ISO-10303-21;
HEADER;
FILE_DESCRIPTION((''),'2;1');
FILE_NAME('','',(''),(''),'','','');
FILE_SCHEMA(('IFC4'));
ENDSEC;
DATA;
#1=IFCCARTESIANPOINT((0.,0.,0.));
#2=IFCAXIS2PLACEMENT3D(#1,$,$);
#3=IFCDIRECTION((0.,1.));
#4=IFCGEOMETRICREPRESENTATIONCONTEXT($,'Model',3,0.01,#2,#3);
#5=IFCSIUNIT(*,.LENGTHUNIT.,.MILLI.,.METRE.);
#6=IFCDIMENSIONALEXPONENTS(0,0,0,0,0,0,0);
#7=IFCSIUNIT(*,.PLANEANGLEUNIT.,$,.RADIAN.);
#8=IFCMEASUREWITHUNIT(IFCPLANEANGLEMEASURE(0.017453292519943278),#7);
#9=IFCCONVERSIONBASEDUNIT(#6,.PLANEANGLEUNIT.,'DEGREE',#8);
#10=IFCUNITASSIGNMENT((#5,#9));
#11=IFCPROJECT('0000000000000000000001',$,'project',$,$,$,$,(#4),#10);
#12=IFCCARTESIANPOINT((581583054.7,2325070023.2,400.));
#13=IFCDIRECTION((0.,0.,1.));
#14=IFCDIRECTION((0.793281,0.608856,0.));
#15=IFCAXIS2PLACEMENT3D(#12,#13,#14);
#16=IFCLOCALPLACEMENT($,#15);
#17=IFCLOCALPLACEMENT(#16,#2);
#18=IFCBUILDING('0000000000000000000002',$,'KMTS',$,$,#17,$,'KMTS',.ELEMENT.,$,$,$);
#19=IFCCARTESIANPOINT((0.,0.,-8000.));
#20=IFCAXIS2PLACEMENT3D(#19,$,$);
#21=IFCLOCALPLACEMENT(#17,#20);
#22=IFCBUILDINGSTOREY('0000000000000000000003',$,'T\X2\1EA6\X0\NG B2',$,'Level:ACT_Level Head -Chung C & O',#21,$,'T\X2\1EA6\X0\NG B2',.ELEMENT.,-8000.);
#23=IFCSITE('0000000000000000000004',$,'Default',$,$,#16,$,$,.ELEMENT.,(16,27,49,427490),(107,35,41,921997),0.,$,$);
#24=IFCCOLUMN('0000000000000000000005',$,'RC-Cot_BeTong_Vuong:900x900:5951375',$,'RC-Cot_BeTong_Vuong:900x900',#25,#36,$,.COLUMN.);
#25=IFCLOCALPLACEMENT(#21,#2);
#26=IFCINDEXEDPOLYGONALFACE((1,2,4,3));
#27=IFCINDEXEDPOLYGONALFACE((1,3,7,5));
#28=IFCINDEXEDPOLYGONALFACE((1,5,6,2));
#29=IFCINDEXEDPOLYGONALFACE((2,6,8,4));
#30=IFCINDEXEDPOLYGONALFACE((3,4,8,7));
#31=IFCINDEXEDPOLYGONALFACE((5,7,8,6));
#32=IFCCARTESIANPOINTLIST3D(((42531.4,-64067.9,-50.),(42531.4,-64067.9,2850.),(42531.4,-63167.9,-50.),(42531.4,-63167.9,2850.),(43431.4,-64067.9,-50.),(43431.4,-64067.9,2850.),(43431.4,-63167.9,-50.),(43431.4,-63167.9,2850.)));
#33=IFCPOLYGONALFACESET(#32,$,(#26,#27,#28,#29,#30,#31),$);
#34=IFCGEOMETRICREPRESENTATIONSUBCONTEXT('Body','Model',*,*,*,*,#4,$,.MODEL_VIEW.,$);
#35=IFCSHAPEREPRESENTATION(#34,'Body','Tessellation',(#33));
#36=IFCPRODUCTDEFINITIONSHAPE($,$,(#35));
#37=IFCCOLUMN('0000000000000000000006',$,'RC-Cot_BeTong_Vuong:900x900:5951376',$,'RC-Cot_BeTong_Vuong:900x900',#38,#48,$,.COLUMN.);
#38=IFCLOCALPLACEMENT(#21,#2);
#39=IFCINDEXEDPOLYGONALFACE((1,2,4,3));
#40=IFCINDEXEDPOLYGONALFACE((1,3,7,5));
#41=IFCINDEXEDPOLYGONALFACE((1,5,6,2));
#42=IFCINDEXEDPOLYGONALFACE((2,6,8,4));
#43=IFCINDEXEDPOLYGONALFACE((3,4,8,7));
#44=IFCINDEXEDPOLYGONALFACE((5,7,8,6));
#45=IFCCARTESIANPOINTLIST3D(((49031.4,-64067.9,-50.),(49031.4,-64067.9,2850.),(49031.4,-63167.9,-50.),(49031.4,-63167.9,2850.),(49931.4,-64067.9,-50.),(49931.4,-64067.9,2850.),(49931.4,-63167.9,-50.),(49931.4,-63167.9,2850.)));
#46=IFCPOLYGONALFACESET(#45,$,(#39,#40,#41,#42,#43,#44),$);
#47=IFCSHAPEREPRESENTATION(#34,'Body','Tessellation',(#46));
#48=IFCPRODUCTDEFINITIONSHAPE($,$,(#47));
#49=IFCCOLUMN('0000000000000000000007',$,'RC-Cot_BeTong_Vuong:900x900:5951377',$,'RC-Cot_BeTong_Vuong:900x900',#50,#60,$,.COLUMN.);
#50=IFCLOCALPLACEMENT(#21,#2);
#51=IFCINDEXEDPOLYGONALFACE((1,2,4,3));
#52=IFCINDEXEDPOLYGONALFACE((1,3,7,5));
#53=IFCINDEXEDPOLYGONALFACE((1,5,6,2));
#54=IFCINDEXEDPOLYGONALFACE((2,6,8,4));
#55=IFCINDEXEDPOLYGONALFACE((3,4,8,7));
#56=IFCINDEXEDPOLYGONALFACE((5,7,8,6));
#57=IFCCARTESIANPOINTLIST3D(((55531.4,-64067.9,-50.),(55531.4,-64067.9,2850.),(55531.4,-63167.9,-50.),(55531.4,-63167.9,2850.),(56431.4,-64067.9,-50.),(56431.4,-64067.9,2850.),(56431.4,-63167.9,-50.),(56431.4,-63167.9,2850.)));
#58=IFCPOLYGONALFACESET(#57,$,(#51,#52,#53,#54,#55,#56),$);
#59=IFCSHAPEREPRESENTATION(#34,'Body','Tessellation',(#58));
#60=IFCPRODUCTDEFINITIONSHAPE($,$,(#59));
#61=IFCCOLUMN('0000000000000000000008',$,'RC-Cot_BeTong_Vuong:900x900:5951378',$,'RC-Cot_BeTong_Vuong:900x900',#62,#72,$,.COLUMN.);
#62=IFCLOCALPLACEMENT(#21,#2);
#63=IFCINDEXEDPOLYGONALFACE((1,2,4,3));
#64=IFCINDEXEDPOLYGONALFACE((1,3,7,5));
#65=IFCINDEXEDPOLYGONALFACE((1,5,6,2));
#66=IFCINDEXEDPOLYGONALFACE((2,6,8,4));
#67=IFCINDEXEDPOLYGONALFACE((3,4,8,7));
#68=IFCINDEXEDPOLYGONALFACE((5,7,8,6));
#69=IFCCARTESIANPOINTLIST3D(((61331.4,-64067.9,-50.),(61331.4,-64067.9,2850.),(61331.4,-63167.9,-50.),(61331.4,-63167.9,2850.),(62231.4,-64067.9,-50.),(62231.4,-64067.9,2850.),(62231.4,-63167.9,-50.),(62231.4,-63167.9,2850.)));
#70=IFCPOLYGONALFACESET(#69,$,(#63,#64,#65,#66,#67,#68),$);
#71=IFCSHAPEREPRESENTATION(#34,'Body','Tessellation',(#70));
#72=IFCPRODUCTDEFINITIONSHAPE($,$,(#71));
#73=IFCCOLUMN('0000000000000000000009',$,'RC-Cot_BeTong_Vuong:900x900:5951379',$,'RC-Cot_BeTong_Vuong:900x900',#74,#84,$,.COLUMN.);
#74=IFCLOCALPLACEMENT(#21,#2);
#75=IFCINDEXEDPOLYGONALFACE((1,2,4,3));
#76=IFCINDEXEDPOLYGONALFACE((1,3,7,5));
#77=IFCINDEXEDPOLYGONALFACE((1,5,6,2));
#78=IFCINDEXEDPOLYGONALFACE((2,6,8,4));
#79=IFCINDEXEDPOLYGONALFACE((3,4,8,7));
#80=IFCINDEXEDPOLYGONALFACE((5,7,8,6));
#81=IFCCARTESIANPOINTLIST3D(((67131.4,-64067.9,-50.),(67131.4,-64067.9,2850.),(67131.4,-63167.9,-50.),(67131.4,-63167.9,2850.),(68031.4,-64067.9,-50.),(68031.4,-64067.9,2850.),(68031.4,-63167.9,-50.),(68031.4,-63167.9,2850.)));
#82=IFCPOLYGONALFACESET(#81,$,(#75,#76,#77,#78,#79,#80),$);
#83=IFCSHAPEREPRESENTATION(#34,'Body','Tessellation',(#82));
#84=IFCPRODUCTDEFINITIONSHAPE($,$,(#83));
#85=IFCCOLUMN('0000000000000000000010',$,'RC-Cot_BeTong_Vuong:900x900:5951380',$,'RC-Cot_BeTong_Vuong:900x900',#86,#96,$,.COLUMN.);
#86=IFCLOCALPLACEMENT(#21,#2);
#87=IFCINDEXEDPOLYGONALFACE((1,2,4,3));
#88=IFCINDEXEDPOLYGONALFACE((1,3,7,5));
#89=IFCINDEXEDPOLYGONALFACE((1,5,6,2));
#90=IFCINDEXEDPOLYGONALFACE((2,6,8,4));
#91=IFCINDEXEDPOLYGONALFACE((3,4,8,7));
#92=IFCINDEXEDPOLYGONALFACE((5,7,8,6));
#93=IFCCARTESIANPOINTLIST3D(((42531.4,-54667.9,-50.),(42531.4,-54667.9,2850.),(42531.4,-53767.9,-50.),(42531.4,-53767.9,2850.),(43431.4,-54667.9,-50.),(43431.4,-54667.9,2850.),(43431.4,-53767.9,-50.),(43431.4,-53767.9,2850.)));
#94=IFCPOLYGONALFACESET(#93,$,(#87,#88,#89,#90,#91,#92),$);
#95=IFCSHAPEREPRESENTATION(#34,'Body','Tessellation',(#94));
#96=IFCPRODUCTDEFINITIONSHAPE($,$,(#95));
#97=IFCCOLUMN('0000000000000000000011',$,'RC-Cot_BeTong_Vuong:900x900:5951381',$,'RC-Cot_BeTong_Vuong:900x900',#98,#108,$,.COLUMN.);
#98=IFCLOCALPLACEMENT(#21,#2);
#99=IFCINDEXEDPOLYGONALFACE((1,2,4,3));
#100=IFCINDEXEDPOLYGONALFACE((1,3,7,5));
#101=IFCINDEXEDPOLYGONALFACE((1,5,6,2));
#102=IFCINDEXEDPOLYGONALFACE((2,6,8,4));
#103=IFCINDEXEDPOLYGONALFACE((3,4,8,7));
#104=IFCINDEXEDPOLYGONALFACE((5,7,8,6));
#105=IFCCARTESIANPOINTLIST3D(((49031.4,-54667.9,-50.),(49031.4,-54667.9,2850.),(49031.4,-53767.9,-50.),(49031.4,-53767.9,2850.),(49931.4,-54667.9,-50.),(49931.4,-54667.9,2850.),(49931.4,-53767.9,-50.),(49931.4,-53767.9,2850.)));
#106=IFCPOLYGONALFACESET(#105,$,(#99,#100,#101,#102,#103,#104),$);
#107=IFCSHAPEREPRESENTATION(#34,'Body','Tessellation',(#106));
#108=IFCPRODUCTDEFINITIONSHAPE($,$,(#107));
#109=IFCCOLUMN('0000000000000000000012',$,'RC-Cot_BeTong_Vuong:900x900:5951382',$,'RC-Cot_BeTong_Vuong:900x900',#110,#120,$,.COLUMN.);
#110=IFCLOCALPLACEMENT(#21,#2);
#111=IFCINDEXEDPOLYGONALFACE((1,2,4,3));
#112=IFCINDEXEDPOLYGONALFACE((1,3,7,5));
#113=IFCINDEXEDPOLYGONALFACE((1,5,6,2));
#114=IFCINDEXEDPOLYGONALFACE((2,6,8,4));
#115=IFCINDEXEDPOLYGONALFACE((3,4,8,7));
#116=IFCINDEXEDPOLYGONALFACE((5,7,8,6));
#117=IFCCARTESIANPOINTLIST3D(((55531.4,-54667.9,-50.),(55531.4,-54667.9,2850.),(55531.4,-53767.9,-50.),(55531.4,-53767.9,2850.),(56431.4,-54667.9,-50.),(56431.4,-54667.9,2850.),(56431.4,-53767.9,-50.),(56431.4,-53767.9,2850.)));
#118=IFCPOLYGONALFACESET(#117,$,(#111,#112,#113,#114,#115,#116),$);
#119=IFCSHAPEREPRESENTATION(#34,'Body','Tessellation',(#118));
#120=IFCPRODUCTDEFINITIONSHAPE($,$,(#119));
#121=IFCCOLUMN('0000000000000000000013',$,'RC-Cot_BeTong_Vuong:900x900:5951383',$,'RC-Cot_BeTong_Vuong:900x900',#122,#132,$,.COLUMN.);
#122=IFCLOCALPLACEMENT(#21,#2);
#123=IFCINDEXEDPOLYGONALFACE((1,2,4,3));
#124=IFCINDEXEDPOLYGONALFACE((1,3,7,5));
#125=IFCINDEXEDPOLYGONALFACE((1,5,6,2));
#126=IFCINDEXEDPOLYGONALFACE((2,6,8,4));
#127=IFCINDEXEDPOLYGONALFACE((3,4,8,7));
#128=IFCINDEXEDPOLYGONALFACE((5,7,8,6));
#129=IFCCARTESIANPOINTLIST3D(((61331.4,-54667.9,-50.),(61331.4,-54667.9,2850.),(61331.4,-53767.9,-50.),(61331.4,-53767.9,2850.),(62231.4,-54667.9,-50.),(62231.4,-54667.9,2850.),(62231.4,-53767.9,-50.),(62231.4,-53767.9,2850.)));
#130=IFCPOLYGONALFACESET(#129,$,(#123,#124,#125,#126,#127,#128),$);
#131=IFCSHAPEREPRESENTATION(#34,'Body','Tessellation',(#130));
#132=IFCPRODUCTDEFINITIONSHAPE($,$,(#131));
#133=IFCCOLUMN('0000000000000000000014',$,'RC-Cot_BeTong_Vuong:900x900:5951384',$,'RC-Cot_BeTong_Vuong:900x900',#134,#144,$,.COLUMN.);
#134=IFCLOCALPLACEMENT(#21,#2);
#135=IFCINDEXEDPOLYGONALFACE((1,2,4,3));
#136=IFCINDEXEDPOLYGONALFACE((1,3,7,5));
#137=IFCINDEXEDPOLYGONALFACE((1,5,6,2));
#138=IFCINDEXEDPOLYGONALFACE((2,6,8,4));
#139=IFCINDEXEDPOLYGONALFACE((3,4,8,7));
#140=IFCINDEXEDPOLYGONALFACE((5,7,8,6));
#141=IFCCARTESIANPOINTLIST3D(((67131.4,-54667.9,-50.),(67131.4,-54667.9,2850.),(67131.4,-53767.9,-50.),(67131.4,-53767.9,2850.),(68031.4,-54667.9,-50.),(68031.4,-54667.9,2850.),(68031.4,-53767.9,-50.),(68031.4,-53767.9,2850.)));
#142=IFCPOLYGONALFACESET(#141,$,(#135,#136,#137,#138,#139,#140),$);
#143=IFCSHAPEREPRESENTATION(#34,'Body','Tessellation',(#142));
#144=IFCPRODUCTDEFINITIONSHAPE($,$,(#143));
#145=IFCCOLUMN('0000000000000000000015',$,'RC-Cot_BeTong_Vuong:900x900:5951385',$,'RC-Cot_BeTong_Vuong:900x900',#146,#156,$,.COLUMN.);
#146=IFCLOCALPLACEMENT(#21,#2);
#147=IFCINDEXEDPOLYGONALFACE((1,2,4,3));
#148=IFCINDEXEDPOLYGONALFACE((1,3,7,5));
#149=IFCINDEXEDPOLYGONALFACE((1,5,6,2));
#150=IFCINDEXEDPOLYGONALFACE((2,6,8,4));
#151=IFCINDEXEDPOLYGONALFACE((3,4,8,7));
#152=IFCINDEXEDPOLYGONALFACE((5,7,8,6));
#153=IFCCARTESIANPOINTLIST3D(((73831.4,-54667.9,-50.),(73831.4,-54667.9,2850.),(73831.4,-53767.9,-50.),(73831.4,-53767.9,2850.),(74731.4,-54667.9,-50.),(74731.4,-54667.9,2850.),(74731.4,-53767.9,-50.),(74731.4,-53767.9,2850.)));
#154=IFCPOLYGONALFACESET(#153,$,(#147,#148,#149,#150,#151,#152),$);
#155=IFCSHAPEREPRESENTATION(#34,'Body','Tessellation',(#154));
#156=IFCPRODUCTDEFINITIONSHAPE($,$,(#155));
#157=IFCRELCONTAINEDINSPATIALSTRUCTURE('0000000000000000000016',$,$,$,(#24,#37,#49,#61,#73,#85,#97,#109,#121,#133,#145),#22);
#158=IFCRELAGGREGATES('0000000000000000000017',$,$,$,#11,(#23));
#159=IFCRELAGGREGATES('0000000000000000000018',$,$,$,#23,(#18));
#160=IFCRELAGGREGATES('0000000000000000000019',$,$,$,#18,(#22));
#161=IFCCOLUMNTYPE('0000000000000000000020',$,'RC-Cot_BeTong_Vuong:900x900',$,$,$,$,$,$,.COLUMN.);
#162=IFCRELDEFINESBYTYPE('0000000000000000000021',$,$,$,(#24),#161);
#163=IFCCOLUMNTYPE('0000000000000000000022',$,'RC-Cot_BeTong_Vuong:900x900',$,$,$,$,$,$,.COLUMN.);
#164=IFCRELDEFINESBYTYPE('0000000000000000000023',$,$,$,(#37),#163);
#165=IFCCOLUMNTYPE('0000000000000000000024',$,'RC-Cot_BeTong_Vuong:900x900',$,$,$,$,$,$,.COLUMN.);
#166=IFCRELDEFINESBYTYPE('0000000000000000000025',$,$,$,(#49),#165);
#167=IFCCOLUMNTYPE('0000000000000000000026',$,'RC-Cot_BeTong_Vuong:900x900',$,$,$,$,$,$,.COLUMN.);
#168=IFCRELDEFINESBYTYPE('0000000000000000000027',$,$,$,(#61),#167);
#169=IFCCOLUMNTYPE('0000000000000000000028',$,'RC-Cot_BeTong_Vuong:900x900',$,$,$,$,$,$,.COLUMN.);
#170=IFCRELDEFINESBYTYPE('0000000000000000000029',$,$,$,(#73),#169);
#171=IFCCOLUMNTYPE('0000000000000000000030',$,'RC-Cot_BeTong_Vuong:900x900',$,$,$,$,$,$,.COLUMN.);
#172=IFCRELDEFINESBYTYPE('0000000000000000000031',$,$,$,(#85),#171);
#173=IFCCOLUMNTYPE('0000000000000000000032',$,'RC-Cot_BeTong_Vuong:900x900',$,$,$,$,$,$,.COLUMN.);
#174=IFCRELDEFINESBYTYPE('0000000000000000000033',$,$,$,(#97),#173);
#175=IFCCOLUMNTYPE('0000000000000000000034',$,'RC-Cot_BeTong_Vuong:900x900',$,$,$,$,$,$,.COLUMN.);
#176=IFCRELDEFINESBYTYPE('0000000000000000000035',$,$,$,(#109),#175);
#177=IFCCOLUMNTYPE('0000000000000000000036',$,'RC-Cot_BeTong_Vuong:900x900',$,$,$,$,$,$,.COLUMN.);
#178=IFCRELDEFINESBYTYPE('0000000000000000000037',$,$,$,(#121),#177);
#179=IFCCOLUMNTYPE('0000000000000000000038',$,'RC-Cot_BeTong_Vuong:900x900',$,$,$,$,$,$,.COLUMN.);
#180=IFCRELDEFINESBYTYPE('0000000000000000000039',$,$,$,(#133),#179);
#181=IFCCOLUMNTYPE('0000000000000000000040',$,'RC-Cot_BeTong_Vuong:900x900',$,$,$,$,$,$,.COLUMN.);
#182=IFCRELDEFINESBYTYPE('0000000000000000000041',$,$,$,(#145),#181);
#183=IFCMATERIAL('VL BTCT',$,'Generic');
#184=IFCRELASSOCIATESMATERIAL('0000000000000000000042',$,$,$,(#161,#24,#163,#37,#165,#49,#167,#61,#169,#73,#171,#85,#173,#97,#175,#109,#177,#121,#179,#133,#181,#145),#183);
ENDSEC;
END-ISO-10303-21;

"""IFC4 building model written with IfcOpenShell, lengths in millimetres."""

from ifc_helpers import new_model, entity, si_unit, converted_unit, direction, frame, origin, place, context, subcontext, project, spatial, indexed_curve, outline, extrude, source, transform, mapped, material, type_object, type_shapes, element, save


model = new_model("IFC4")

# Units and contexts
model_context = context("Model", 3, precision=0.01, world=origin(), true_north=direction((0.0, 1.0)))
body_context = subcontext(model_context, "Body", "Model", "MODEL_VIEW")
ifc_project = project(units=[si_unit("LENGTHUNIT", "METRE", prefix="MILLI"), converted_unit("PLANEANGLEUNIT", "DEGREE", entity("IfcPlaneAngleMeasure", 0.017453292519943278), si_unit("PLANEANGLEUNIT", "RADIAN"), dimensions=[0, 0, 0, 0, 0, 0, 0])], contexts=[model_context])

# Site, building, storey
site_placement = place(None, frame((581583054.7, 2325070023.2, 400.0), z_axis=(0.0, 0.0, 1.0), x_axis=(0.793281, 0.608856, 0.0)))
site = spatial("IfcSite", under=ifc_project, at=site_placement, Name="Default", CompositionType="ELEMENT", RefLatitude=(16, 27, 49, 427490), RefLongitude=(107, 35, 41, 921997), RefElevation=0.0)
building_placement = place(site_placement, origin())
building = spatial("IfcBuilding", under=site, at=building_placement, Name="KMTS", LongName="KMTS", CompositionType="ELEMENT")
storey_placement = place(building_placement, frame((0.0, 0.0, -8000.0)))
storey = spatial("IfcBuildingStorey", under=building, at=storey_placement, Name="TẦNG B2", ObjectType="Level:ACT_Level Head -Chung C & O", LongName="TẦNG B2", CompositionType="ELEMENT", Elevation=-8000.0)

# Columns
ifc_material = material(Name="VL BTCT", Category="Generic")
column_type_1 = type_object("IfcColumnType", Name="RC-Cot_BeTong_Vuong:900x900", PredefinedType="COLUMN", material=ifc_material)
shared_shape_1 = source(origin(), body_context, "Body", "SweptSolid", [
    extrude(outline(indexed_curve([(-450.0, -450.0), (450.0, -450.0), (450.0, 450.0), (-450.0, 450.0), (-450.0, -450.0)], self_intersect=False)), frame((42981.4, -63617.9, -8050.0), z_axis=(0.0, 0.0, 1.0), x_axis=(-1.0, 0.0, 0.0)), (0.0, 0.0, 1.0), 2900.0),
])
type_shapes(column_type_1, [shared_shape_1])
column_1_placement = place(storey_placement, frame((0.0, 0.0, 8000.0)))
element("IfcColumn", 1, at=column_1_placement, inside=storey, type_object=column_type_1, material=ifc_material, Name="RC-Cot_BeTong_Vuong:900x900:5951375", ObjectType="RC-Cot_BeTong_Vuong:900x900", PredefinedType="COLUMN", context=body_context, shape_type="MappedRepresentation", body=[
    mapped(shared_shape_1, transform((0.0, 0.0, 0.0), scale=1.0)),
])
column_type_2 = type_object("IfcColumnType", Name="RC-Cot_BeTong_Vuong:900x900", PredefinedType="COLUMN", material=ifc_material)
shared_shape_2 = source(origin(), body_context, "Body", "SweptSolid", [
    extrude(outline(indexed_curve([(-450.0, -450.0), (450.0, -450.0), (450.0, 450.0), (-450.0, 450.0), (-450.0, -450.0)], self_intersect=False)), frame((49481.4, -63617.9, -8050.0), z_axis=(0.0, 0.0, 1.0), x_axis=(-1.0, 0.0, 0.0)), (0.0, 0.0, 1.0), 2900.0),
])
type_shapes(column_type_2, [shared_shape_2])
column_2_placement = place(storey_placement, frame((0.0, 0.0, 8000.0)))
element("IfcColumn", 2, at=column_2_placement, inside=storey, type_object=column_type_2, material=ifc_material, Name="RC-Cot_BeTong_Vuong:900x900:5951376", ObjectType="RC-Cot_BeTong_Vuong:900x900", PredefinedType="COLUMN", context=body_context, shape_type="MappedRepresentation", body=[
    mapped(shared_shape_2, transform((0.0, 0.0, 0.0), scale=1.0)),
])
column_type_3 = type_object("IfcColumnType", Name="RC-Cot_BeTong_Vuong:900x900", PredefinedType="COLUMN", material=ifc_material)
shared_shape_3 = source(origin(), body_context, "Body", "SweptSolid", [
    extrude(outline(indexed_curve([(-450.0, -450.0), (450.0, -450.0), (450.0, 450.0), (-450.0, 450.0), (-450.0, -450.0)], self_intersect=False)), frame((55981.4, -63617.9, -8050.0), z_axis=(0.0, 0.0, 1.0), x_axis=(-1.0, 0.0, 0.0)), (0.0, 0.0, 1.0), 2900.0),
])
type_shapes(column_type_3, [shared_shape_3])
column_3_placement = place(storey_placement, frame((0.0, 0.0, 8000.0)))
element("IfcColumn", 3, at=column_3_placement, inside=storey, type_object=column_type_3, material=ifc_material, Name="RC-Cot_BeTong_Vuong:900x900:5951377", ObjectType="RC-Cot_BeTong_Vuong:900x900", PredefinedType="COLUMN", context=body_context, shape_type="MappedRepresentation", body=[
    mapped(shared_shape_3, transform((0.0, 0.0, 0.0), scale=1.0)),
])
column_type_4 = type_object("IfcColumnType", Name="RC-Cot_BeTong_Vuong:900x900", PredefinedType="COLUMN", material=ifc_material)
shared_shape_4 = source(origin(), body_context, "Body", "SweptSolid", [
    extrude(outline(indexed_curve([(-450.0, -450.0), (450.0, -450.0), (450.0, 450.0), (-450.0, 450.0), (-450.0, -450.0)], self_intersect=False)), frame((61781.4, -63617.9, -8050.0), z_axis=(0.0, 0.0, 1.0), x_axis=(-1.0, 0.0, 0.0)), (0.0, 0.0, 1.0), 2900.0),
])
type_shapes(column_type_4, [shared_shape_4])
column_4_placement = place(storey_placement, frame((0.0, 0.0, 8000.0)))
element("IfcColumn", 4, at=column_4_placement, inside=storey, type_object=column_type_4, material=ifc_material, Name="RC-Cot_BeTong_Vuong:900x900:5951378", ObjectType="RC-Cot_BeTong_Vuong:900x900", PredefinedType="COLUMN", context=body_context, shape_type="MappedRepresentation", body=[
    mapped(shared_shape_4, transform((0.0, 0.0, 0.0), scale=1.0)),
])
column_type_5 = type_object("IfcColumnType", Name="RC-Cot_BeTong_Vuong:900x900", PredefinedType="COLUMN", material=ifc_material)
shared_shape_5 = source(origin(), body_context, "Body", "SweptSolid", [
    extrude(outline(indexed_curve([(-450.0, -450.0), (450.0, -450.0), (450.0, 450.0), (-450.0, 450.0), (-450.0, -450.0)], self_intersect=False)), frame((67581.4, -63617.9, -8050.0), z_axis=(0.0, 0.0, 1.0), x_axis=(-1.0, 0.0, 0.0)), (0.0, 0.0, 1.0), 2900.0),
])
type_shapes(column_type_5, [shared_shape_5])
column_5_placement = place(storey_placement, frame((0.0, 0.0, 8000.0)))
element("IfcColumn", 5, at=column_5_placement, inside=storey, type_object=column_type_5, material=ifc_material, Name="RC-Cot_BeTong_Vuong:900x900:5951379", ObjectType="RC-Cot_BeTong_Vuong:900x900", PredefinedType="COLUMN", context=body_context, shape_type="MappedRepresentation", body=[
    mapped(shared_shape_5, transform((0.0, 0.0, 0.0), scale=1.0)),
])
column_type_6 = type_object("IfcColumnType", Name="RC-Cot_BeTong_Vuong:900x900", PredefinedType="COLUMN", material=ifc_material)
shared_shape_6 = source(origin(), body_context, "Body", "SweptSolid", [
    extrude(outline(indexed_curve([(-450.0, -450.0), (450.0, -450.0), (450.0, 450.0), (-450.0, 450.0), (-450.0, -450.0)], self_intersect=False)), frame((42981.4, -54217.9, -8050.0), z_axis=(0.0, 0.0, 1.0), x_axis=(-1.0, 0.0, 0.0)), (0.0, 0.0, 1.0), 2900.0),
])
type_shapes(column_type_6, [shared_shape_6])
column_6_placement = place(storey_placement, frame((0.0, 0.0, 8000.0)))
element("IfcColumn", 6, at=column_6_placement, inside=storey, type_object=column_type_6, material=ifc_material, Name="RC-Cot_BeTong_Vuong:900x900:5951380", ObjectType="RC-Cot_BeTong_Vuong:900x900", PredefinedType="COLUMN", context=body_context, shape_type="MappedRepresentation", body=[
    mapped(shared_shape_6, transform((0.0, 0.0, 0.0), scale=1.0)),
])
column_type_7 = type_object("IfcColumnType", Name="RC-Cot_BeTong_Vuong:900x900", PredefinedType="COLUMN", material=ifc_material)
shared_shape_7 = source(origin(), body_context, "Body", "SweptSolid", [
    extrude(outline(indexed_curve([(-450.0, -450.0), (450.0, -450.0), (450.0, 450.0), (-450.0, 450.0), (-450.0, -450.0)], self_intersect=False)), frame((49481.4, -54217.9, -8050.0), z_axis=(0.0, 0.0, 1.0), x_axis=(-1.0, 0.0, 0.0)), (0.0, 0.0, 1.0), 2900.0),
])
type_shapes(column_type_7, [shared_shape_7])
column_7_placement = place(storey_placement, frame((0.0, 0.0, 8000.0)))
element("IfcColumn", 7, at=column_7_placement, inside=storey, type_object=column_type_7, material=ifc_material, Name="RC-Cot_BeTong_Vuong:900x900:5951381", ObjectType="RC-Cot_BeTong_Vuong:900x900", PredefinedType="COLUMN", context=body_context, shape_type="MappedRepresentation", body=[
    mapped(shared_shape_7, transform((0.0, 0.0, 0.0), scale=1.0)),
])
column_type_8 = type_object("IfcColumnType", Name="RC-Cot_BeTong_Vuong:900x900", PredefinedType="COLUMN", material=ifc_material)
shared_shape_8 = source(origin(), body_context, "Body", "SweptSolid", [
    extrude(outline(indexed_curve([(-450.0, -450.0), (450.0, -450.0), (450.0, 450.0), (-450.0, 450.0), (-450.0, -450.0)], self_intersect=False)), frame((55981.4, -54217.9, -8050.0), z_axis=(0.0, 0.0, 1.0), x_axis=(-1.0, 0.0, 0.0)), (0.0, 0.0, 1.0), 2900.0),
])
type_shapes(column_type_8, [shared_shape_8])
column_8_placement = place(storey_placement, frame((0.0, 0.0, 8000.0)))
element("IfcColumn", 8, at=column_8_placement, inside=storey, type_object=column_type_8, material=ifc_material, Name="RC-Cot_BeTong_Vuong:900x900:5951382", ObjectType="RC-Cot_BeTong_Vuong:900x900", PredefinedType="COLUMN", context=body_context, shape_type="MappedRepresentation", body=[
    mapped(shared_shape_8, transform((0.0, 0.0, 0.0), scale=1.0)),
])
column_type_9 = type_object("IfcColumnType", Name="RC-Cot_BeTong_Vuong:900x900", PredefinedType="COLUMN", material=ifc_material)
shared_shape_9 = source(origin(), body_context, "Body", "SweptSolid", [
    extrude(outline(indexed_curve([(-450.0, -450.0), (450.0, -450.0), (450.0, 450.0), (-450.0, 450.0), (-450.0, -450.0)], self_intersect=False)), frame((61781.4, -54217.9, -8050.0), z_axis=(0.0, 0.0, 1.0), x_axis=(-1.0, 0.0, 0.0)), (0.0, 0.0, 1.0), 2900.0),
])
type_shapes(column_type_9, [shared_shape_9])
column_9_placement = place(storey_placement, frame((0.0, 0.0, 8000.0)))
element("IfcColumn", 9, at=column_9_placement, inside=storey, type_object=column_type_9, material=ifc_material, Name="RC-Cot_BeTong_Vuong:900x900:5951383", ObjectType="RC-Cot_BeTong_Vuong:900x900", PredefinedType="COLUMN", context=body_context, shape_type="MappedRepresentation", body=[
    mapped(shared_shape_9, transform((0.0, 0.0, 0.0), scale=1.0)),
])
column_type_10 = type_object("IfcColumnType", Name="RC-Cot_BeTong_Vuong:900x900", PredefinedType="COLUMN", material=ifc_material)
shared_shape_10 = source(origin(), body_context, "Body", "SweptSolid", [
    extrude(outline(indexed_curve([(-450.0, -450.0), (450.0, -450.0), (450.0, 450.0), (-450.0, 450.0), (-450.0, -450.0)], self_intersect=False)), frame((67581.4, -54217.9, -8050.0), z_axis=(0.0, 0.0, 1.0), x_axis=(-1.0, 0.0, 0.0)), (0.0, 0.0, 1.0), 2900.0),
])
type_shapes(column_type_10, [shared_shape_10])
column_10_placement = place(storey_placement, frame((0.0, 0.0, 8000.0)))
element("IfcColumn", 10, at=column_10_placement, inside=storey, type_object=column_type_10, material=ifc_material, Name="RC-Cot_BeTong_Vuong:900x900:5951384", ObjectType="RC-Cot_BeTong_Vuong:900x900", PredefinedType="COLUMN", context=body_context, shape_type="MappedRepresentation", body=[
    mapped(shared_shape_10, transform((0.0, 0.0, 0.0), scale=1.0)),
])
column_type_11 = type_object("IfcColumnType", Name="RC-Cot_BeTong_Vuong:900x900", PredefinedType="COLUMN", material=ifc_material)
shared_shape_11 = source(origin(), body_context, "Body", "SweptSolid", [
    extrude(outline(indexed_curve([(-450.0, -450.0), (450.0, -450.0), (450.0, 450.0), (-450.0, 450.0), (-450.0, -450.0)], self_intersect=False)), frame((74281.4, -54217.9, -8050.0), z_axis=(0.0, 0.0, 1.0), x_axis=(-1.0, 0.0, 0.0)), (0.0, 0.0, 1.0), 2900.0),
])
type_shapes(column_type_11, [shared_shape_11])
column_11_placement = place(storey_placement, frame((0.0, 0.0, 8000.0)))
element("IfcColumn", 11, at=column_11_placement, inside=storey, type_object=column_type_11, material=ifc_material, Name="RC-Cot_BeTong_Vuong:900x900:5951385", ObjectType="RC-Cot_BeTong_Vuong:900x900", PredefinedType="COLUMN", context=body_context, shape_type="MappedRepresentation", body=[
    mapped(shared_shape_11, transform((0.0, 0.0, 0.0), scale=1.0)),
])

save(model, "model.ifc")
